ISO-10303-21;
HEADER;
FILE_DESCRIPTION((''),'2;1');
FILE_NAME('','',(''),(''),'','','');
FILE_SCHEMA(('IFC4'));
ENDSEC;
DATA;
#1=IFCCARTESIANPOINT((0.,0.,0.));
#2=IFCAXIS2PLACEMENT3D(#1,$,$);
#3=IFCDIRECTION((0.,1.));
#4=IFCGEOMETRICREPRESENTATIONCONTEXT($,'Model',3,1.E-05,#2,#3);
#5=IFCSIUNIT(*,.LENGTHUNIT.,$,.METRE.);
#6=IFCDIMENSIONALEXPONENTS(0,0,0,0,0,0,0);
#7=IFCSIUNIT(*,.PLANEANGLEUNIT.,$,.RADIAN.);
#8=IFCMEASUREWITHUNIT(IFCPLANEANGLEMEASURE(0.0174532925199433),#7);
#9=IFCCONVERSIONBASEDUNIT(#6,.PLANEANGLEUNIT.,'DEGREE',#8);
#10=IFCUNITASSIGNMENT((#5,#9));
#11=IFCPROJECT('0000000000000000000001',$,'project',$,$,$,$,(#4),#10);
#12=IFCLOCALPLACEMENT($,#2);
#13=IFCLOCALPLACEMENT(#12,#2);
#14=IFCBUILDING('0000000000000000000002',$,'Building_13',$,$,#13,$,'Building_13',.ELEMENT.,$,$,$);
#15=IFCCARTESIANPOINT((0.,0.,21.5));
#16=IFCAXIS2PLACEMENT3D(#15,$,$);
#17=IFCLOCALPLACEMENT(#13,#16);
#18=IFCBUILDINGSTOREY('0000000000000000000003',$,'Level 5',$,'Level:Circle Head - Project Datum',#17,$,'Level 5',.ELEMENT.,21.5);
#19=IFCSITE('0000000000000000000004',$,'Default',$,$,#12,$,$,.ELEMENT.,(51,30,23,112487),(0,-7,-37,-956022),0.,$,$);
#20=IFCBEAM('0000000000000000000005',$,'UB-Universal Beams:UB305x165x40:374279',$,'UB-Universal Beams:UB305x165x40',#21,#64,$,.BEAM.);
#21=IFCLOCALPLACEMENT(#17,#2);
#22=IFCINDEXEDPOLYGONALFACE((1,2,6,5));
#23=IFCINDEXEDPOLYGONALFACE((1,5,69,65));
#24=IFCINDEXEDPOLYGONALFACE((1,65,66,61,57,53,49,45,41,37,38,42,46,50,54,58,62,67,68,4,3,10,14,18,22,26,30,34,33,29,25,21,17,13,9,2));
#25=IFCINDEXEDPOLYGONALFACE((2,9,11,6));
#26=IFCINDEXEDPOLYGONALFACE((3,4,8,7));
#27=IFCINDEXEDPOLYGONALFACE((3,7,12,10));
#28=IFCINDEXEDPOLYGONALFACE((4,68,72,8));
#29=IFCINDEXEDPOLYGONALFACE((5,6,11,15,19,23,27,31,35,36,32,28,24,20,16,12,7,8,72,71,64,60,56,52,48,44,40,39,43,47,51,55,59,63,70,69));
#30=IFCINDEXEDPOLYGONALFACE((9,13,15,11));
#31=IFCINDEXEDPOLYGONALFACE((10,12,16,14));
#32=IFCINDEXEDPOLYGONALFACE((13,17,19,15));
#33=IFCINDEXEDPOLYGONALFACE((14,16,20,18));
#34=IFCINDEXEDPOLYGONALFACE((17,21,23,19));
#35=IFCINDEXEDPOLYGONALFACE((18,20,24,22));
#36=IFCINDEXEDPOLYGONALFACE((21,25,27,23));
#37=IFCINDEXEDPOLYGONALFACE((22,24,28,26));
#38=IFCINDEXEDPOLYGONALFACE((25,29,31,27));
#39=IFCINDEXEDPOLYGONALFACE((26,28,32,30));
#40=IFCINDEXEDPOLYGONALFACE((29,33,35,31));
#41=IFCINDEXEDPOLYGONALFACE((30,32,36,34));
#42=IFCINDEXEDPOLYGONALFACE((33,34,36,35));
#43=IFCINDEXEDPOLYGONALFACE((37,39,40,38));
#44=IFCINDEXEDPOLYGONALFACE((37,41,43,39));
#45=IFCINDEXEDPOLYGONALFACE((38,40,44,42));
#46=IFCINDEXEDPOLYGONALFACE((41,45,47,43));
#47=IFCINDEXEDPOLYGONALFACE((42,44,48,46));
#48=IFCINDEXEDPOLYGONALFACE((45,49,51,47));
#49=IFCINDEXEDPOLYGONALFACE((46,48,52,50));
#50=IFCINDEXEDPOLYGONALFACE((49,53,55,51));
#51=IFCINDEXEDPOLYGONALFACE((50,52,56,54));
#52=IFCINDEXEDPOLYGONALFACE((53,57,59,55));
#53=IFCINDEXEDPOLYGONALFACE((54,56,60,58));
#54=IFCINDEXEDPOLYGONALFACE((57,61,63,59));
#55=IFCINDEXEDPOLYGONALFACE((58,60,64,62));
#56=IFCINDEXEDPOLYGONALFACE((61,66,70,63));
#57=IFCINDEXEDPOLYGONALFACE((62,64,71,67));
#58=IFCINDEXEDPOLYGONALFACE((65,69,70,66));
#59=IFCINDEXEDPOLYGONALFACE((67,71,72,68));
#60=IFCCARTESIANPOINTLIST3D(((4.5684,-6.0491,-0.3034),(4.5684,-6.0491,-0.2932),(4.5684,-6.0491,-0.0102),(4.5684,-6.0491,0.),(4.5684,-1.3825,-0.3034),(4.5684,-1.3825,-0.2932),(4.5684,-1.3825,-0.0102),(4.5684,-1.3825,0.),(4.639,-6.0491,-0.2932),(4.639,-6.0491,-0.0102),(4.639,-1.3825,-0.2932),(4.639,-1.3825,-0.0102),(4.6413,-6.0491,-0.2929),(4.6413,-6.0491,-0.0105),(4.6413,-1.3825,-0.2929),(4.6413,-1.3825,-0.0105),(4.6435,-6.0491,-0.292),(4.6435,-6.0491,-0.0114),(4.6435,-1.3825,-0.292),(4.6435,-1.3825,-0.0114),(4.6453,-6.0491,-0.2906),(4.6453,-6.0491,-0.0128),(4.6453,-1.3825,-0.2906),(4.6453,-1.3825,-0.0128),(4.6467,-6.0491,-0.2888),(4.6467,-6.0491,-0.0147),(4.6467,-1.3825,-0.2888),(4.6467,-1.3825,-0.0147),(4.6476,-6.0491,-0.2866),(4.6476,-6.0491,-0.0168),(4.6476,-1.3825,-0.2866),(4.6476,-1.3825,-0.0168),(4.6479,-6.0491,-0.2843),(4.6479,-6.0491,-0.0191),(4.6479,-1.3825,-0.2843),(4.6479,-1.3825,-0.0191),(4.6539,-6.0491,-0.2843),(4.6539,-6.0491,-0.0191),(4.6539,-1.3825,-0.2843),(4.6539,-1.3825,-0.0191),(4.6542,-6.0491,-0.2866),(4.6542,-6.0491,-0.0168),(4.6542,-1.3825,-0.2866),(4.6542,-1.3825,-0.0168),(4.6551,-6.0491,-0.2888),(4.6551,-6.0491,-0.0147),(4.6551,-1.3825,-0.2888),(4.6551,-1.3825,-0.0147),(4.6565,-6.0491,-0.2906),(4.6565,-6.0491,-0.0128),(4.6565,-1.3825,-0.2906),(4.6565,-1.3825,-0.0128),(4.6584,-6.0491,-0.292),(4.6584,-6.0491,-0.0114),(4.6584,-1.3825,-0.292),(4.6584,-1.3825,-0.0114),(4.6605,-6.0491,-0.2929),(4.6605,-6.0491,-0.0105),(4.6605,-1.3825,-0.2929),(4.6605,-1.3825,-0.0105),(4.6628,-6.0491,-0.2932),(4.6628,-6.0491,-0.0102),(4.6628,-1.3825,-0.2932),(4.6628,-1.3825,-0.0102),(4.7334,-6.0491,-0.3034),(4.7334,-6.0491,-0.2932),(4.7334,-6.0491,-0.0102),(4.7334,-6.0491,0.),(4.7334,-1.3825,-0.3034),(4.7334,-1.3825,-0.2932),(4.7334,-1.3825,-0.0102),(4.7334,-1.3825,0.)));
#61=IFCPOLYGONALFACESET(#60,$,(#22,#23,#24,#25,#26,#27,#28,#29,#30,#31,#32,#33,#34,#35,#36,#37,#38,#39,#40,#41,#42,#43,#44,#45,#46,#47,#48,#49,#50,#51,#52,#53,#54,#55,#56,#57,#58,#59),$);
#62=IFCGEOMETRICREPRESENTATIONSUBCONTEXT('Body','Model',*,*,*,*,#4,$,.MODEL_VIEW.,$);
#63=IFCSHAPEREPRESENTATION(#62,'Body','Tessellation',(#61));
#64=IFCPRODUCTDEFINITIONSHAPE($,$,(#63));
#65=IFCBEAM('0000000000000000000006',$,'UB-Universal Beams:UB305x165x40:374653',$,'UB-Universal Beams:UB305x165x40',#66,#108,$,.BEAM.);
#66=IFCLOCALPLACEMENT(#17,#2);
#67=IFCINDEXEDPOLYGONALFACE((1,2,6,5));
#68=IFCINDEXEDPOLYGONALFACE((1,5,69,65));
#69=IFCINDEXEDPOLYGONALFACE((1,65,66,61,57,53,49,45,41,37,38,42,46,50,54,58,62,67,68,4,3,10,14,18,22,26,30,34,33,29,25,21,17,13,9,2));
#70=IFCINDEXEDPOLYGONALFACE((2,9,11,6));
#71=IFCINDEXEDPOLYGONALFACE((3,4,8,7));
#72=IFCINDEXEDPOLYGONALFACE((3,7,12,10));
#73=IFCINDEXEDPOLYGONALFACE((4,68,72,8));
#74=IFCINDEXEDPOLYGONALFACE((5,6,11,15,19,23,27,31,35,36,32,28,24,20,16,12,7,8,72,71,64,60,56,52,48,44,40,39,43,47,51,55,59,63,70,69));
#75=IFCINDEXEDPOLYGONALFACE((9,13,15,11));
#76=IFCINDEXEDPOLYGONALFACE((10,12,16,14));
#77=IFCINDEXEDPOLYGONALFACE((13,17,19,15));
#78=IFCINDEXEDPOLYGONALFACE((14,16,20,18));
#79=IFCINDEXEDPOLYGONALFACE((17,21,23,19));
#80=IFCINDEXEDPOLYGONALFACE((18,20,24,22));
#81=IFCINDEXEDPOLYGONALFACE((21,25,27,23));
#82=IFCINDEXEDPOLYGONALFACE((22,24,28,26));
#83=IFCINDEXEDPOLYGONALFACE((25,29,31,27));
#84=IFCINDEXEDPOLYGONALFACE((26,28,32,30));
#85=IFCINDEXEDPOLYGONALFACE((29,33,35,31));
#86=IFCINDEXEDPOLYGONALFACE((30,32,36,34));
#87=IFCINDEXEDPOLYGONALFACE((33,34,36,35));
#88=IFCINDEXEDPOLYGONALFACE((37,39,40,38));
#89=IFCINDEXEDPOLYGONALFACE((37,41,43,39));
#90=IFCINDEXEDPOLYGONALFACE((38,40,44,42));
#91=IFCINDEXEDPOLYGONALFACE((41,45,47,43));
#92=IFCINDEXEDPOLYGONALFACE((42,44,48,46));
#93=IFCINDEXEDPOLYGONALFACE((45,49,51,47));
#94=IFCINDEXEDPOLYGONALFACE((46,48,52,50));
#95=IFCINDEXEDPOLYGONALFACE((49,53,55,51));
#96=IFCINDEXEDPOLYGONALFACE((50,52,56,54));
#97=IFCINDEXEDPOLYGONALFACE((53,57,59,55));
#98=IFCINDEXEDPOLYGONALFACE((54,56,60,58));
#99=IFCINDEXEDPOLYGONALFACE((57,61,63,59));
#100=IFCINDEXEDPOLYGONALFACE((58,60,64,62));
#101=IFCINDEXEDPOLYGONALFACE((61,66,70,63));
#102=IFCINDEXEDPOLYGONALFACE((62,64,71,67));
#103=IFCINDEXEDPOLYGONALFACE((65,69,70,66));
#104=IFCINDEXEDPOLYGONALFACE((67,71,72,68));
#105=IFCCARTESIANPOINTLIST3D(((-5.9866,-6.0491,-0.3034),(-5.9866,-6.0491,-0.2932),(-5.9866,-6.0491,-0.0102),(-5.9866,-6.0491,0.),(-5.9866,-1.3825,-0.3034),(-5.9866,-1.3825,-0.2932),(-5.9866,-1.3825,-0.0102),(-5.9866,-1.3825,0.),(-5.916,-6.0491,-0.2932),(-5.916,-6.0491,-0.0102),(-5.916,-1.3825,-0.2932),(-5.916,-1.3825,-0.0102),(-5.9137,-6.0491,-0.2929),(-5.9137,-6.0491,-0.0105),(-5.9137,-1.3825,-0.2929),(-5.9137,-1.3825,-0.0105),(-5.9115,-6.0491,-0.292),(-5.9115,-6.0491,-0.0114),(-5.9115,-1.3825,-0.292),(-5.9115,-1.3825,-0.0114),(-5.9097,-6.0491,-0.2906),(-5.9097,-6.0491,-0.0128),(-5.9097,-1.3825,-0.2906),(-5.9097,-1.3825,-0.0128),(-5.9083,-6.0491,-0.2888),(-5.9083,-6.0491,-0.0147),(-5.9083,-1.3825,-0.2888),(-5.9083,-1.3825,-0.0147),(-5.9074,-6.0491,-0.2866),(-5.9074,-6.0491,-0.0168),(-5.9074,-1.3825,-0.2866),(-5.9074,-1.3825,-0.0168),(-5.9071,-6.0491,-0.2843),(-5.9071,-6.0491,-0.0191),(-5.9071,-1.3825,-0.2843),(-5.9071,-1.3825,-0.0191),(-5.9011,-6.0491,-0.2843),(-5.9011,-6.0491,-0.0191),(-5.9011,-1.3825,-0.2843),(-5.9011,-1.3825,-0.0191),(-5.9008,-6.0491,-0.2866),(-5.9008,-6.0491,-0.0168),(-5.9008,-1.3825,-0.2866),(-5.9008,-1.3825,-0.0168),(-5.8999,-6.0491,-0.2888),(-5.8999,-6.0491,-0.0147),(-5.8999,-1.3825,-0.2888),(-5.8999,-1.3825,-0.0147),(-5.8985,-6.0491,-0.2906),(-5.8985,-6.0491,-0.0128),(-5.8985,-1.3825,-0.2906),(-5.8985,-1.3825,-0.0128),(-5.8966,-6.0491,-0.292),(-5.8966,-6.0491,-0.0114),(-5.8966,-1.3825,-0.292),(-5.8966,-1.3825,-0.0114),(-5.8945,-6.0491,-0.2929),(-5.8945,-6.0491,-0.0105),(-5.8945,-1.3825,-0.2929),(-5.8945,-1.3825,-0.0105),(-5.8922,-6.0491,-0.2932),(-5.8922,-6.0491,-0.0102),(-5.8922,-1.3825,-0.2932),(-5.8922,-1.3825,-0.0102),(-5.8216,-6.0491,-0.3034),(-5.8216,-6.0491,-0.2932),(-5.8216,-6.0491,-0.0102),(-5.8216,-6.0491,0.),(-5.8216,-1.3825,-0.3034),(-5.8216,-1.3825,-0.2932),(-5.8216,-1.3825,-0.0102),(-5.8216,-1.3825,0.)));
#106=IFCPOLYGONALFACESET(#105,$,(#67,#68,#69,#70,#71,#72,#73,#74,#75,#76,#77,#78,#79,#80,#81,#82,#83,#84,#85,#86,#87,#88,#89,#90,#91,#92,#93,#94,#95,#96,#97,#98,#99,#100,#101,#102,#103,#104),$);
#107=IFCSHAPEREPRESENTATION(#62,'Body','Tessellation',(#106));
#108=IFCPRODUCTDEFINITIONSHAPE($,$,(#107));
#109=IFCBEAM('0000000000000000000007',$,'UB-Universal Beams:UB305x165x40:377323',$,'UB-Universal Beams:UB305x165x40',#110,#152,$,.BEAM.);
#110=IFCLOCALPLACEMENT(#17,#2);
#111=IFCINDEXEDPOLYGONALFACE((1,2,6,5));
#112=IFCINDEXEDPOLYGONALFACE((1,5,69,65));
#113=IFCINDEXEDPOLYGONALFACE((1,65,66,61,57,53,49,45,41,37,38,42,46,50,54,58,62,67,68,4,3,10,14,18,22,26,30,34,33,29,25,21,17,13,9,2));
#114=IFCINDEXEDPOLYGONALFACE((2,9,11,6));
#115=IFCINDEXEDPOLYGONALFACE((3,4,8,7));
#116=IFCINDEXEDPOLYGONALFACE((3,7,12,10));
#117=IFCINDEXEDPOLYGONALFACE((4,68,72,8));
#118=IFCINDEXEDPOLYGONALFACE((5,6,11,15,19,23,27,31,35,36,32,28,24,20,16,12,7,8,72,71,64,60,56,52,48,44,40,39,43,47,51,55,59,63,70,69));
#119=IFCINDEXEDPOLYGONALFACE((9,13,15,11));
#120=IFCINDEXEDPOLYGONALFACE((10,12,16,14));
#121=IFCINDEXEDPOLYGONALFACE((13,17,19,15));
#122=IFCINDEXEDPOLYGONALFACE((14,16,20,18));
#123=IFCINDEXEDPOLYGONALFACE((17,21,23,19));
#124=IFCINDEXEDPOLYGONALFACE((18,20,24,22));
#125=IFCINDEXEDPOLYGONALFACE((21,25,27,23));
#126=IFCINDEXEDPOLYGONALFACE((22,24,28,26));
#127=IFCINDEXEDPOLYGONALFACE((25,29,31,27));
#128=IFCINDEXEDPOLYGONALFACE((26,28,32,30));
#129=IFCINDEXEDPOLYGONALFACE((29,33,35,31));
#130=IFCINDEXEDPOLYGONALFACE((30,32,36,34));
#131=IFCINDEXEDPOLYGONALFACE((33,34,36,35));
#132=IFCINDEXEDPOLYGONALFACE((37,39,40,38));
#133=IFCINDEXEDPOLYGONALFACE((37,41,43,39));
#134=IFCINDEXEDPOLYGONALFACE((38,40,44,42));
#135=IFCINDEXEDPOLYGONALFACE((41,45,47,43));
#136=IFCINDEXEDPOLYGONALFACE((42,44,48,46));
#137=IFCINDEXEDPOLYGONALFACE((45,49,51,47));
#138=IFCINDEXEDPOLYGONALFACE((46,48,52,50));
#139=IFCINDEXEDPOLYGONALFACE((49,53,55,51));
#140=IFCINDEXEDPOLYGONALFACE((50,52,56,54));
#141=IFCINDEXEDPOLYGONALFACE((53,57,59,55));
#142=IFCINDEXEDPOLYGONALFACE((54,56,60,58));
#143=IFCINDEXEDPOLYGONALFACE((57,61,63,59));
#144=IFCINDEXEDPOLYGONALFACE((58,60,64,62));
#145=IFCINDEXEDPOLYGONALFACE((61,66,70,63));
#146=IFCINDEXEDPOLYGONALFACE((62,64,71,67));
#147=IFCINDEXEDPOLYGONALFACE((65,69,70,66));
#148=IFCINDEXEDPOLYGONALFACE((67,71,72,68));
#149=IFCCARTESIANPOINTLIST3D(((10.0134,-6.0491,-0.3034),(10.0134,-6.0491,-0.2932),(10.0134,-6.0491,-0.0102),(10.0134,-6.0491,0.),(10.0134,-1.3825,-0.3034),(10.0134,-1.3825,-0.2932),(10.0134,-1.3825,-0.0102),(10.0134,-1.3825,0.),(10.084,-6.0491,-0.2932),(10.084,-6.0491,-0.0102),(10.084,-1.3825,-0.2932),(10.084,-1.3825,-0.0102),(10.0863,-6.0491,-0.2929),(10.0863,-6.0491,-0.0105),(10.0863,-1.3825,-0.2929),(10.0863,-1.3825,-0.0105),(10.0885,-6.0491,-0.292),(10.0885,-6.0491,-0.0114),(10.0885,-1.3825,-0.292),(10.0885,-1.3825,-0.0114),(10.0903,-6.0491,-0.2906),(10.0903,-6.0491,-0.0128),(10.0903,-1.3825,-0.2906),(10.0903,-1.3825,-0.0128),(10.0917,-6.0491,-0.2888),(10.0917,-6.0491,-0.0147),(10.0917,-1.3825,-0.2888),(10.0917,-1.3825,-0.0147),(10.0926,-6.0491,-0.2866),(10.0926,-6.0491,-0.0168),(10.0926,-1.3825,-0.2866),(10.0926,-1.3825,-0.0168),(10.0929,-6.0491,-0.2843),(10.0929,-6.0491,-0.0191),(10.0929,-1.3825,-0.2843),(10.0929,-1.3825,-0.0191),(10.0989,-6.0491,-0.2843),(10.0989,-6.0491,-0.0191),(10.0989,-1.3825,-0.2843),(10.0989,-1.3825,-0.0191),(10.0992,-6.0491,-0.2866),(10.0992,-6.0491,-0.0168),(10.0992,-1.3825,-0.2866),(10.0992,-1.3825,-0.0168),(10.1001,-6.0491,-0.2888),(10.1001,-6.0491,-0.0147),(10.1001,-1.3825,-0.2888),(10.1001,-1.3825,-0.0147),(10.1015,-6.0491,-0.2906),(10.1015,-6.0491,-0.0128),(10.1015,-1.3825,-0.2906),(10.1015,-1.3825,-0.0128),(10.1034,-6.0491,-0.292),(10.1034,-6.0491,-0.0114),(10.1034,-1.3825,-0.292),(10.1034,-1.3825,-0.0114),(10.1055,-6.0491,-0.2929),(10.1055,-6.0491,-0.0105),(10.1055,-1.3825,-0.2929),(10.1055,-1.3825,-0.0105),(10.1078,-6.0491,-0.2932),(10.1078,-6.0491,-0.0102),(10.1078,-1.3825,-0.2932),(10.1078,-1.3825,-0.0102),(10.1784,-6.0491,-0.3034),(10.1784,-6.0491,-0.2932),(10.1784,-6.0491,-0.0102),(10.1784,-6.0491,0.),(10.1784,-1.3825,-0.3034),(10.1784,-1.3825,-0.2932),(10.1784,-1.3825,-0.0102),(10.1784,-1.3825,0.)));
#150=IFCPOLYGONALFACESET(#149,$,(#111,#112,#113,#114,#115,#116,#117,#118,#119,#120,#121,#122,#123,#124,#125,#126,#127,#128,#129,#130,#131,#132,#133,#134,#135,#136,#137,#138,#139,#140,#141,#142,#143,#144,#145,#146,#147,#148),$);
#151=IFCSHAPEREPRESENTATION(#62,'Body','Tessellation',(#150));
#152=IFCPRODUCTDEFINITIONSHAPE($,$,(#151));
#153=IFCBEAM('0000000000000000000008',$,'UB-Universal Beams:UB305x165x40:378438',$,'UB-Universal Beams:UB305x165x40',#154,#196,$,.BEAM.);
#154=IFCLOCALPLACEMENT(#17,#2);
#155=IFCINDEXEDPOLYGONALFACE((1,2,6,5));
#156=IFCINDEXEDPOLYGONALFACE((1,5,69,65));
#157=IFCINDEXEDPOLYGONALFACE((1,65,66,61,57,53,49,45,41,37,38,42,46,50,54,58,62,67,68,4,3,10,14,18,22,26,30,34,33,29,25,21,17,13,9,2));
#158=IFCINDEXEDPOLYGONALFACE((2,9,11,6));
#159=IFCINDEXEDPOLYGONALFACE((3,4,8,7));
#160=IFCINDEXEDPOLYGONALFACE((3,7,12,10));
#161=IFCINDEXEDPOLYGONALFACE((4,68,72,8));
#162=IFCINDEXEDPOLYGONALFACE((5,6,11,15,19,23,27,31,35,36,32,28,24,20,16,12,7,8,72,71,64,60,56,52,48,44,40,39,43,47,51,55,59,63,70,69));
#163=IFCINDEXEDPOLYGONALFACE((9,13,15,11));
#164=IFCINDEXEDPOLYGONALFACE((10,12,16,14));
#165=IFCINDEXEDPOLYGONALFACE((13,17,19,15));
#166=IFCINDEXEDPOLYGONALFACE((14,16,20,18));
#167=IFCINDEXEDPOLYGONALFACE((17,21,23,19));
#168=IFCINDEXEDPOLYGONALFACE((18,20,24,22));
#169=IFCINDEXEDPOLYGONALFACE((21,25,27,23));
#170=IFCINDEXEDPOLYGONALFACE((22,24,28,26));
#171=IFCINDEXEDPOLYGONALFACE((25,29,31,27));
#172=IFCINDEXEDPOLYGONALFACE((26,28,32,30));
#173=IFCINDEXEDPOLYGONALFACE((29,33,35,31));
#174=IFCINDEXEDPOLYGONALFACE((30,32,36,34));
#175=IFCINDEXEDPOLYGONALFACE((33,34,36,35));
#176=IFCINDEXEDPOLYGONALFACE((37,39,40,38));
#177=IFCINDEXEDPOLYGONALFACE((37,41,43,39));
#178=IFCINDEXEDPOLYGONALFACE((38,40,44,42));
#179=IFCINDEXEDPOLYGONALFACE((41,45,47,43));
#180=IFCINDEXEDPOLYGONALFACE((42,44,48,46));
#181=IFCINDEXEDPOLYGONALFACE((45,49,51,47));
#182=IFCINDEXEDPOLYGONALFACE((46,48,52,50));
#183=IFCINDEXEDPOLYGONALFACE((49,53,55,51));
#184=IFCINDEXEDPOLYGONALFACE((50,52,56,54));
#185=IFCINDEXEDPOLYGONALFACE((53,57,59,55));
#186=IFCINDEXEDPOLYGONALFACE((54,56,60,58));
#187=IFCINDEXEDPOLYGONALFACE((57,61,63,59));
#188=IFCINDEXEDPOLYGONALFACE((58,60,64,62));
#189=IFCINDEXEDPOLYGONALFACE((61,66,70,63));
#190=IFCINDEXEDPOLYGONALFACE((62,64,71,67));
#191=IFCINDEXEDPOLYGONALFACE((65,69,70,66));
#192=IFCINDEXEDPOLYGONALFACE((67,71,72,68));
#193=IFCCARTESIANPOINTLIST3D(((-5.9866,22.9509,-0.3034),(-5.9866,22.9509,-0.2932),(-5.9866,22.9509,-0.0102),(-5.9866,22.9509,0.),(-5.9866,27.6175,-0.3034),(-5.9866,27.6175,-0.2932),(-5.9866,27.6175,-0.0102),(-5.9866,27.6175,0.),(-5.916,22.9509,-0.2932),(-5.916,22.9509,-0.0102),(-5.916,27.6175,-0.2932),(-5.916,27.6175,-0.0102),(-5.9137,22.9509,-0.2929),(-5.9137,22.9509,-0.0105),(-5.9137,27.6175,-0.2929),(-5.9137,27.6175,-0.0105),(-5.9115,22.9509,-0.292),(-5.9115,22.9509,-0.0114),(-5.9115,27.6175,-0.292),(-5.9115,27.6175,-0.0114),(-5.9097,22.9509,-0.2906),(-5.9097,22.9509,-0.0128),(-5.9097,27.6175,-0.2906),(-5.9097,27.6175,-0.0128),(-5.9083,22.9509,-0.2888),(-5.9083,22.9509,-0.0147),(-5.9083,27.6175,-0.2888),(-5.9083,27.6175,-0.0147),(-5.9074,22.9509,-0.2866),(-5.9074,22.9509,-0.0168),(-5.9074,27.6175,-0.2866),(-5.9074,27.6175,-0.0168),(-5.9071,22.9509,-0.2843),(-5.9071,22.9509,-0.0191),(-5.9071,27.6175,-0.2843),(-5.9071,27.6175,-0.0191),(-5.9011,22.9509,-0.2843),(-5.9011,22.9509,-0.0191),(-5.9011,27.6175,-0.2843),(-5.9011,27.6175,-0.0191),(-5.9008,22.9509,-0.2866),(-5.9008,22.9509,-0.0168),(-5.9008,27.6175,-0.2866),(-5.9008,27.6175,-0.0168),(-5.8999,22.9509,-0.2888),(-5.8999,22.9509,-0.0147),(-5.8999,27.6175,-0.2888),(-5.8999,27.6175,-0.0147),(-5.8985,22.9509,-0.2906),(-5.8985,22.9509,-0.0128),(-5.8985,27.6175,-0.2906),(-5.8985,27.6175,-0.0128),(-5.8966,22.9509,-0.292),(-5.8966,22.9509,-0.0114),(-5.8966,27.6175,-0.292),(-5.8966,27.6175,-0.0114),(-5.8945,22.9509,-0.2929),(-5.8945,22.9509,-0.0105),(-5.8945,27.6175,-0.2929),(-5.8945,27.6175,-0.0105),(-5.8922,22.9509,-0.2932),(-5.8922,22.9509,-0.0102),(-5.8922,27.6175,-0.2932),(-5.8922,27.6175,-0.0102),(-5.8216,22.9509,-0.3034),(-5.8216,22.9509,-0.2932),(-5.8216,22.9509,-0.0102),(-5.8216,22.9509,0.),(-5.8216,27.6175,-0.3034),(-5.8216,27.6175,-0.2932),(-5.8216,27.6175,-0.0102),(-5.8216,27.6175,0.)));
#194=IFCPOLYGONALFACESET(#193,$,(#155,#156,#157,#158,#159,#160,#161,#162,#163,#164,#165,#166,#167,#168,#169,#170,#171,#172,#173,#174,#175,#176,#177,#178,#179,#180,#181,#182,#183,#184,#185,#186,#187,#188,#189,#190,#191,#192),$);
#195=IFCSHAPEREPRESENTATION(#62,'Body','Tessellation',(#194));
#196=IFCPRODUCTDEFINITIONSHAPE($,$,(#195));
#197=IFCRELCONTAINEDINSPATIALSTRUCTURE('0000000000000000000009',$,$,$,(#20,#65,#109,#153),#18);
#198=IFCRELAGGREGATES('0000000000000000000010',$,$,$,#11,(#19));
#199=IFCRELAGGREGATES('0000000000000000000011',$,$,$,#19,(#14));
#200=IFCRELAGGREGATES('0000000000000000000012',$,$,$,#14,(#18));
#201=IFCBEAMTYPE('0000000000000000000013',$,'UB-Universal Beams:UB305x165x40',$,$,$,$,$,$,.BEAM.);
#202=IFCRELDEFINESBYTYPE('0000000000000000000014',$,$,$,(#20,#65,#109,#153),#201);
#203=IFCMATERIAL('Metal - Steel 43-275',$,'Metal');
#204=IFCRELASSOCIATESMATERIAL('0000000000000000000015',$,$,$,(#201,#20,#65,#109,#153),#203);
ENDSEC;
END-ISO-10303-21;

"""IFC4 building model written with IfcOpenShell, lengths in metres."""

from ifc_helpers import new_model, entity, si_unit, converted_unit, direction, frame, origin, place, context, subcontext, project, spatial, line, arc, indexed_curve, outline, extrude, source, transform, mapped, material, type_object, type_shapes, element, save


model = new_model("IFC4")

# Units and contexts
model_context = context("Model", 3, precision=1e-05, world=origin(), true_north=direction((0.0, 1.0)))
body_context = subcontext(model_context, "Body", "Model", "MODEL_VIEW")
ifc_project = project(units=[si_unit("LENGTHUNIT", "METRE"), converted_unit("PLANEANGLEUNIT", "DEGREE", entity("IfcPlaneAngleMeasure", 0.0174532925199433), si_unit("PLANEANGLEUNIT", "RADIAN"), dimensions=[0, 0, 0, 0, 0, 0, 0])], contexts=[model_context])

# Site, building, storey
site_placement = place(None, origin())
site = spatial("IfcSite", under=ifc_project, at=site_placement, Name="Default", CompositionType="ELEMENT", RefLatitude=(51, 30, 23, 112487), RefLongitude=(0, -7, -37, -956022), RefElevation=0.0)
building_placement = place(site_placement, origin())
building = spatial("IfcBuilding", under=site, at=building_placement, Name="Building_13", LongName="Building_13", CompositionType="ELEMENT")
storey_placement = place(building_placement, frame((0.0, 0.0, 21.5)))
storey = spatial("IfcBuildingStorey", under=building, at=storey_placement, Name="Level 5", ObjectType="Level:Circle Head - Project Datum", LongName="Level 5", CompositionType="ELEMENT", Elevation=21.5)

# Beams
ifc_material = material(Name="Metal - Steel 43-275", Category="Metal")
beam_type_1 = type_object("IfcBeamType", Name="UB-Universal Beams:UB305x165x40", PredefinedType="BEAM", material=ifc_material)
shared_shape_1 = source(origin(), body_context, "Body", "SweptSolid", [
    extrude(outline(indexed_curve([(-0.0825, -0.1415), (-0.0825, -0.1517), (0.0825, -0.1517), (0.0825, -0.1415), (0.0119, -0.1415), (0.0056, -0.1389), (0.003, -0.1326), (0.003, 0.1326), (0.0056, 0.1389), (0.0119, 0.1415), (0.0825, 0.1415), (0.0825, 0.1517), (-0.0825, 0.1517), (-0.0825, 0.1415), (-0.0119, 0.1415), (-0.0056, 0.1389), (-0.003, 0.1326), (-0.003, -0.1326), (-0.0056, -0.1389), (-0.0119, -0.1415)], segments=[line(1, 2, 3, 4, 5), arc(5, 6, 7), line(7, 8), arc(8, 9, 10), line(10, 11, 12, 13, 14, 15), arc(15, 16, 17), line(17, 18), arc(18, 19, 20), line(20, 1)], self_intersect=False)), frame((-2.3333, 0.0, 0.0), z_axis=(-1.0, 0.0, 0.0), x_axis=(0.0, -1.0, 0.0)), (0.0, 0.0, -1.0), 4.6666),
])
type_shapes(beam_type_1, [shared_shape_1])
for number, where, z_axis, x_axis, name in (
    (1, (4.6509, -3.7158, -0.1517), (0.0, 0.0, 1.0), (0.0, -1.0, 0.0), "UB-Universal Beams:UB305x165x40:374279"),
    (2, (-5.9041, -3.7158, -0.1517), (0.0, 0.0, 1.0), (0.0, -1.0, 0.0), "UB-Universal Beams:UB305x165x40:374653"),
    (3, (10.0959, -3.7158, -0.1517), (0.0, 0.0, 1.0), (0.0, -1.0, 0.0), "UB-Universal Beams:UB305x165x40:377323"),
    (4, (-5.9041, 25.2842, -0.1517), (0.0, 0.0, 1.0), (0.0, -1.0, 0.0), "UB-Universal Beams:UB305x165x40:378438"),
):
    element("IfcBeam", number, at=place(storey_placement, frame(where, z_axis=z_axis, x_axis=x_axis)), inside=storey, type_object=beam_type_1, material=ifc_material, Name=name, ObjectType="UB-Universal Beams:UB305x165x40", PredefinedType="BEAM", context=body_context, shape_type="MappedRepresentation", body=[
        mapped(shared_shape_1, transform((0.0, 0.0, 0.0), scale=1.0)),
    ])

save(model, "model.ifc")
